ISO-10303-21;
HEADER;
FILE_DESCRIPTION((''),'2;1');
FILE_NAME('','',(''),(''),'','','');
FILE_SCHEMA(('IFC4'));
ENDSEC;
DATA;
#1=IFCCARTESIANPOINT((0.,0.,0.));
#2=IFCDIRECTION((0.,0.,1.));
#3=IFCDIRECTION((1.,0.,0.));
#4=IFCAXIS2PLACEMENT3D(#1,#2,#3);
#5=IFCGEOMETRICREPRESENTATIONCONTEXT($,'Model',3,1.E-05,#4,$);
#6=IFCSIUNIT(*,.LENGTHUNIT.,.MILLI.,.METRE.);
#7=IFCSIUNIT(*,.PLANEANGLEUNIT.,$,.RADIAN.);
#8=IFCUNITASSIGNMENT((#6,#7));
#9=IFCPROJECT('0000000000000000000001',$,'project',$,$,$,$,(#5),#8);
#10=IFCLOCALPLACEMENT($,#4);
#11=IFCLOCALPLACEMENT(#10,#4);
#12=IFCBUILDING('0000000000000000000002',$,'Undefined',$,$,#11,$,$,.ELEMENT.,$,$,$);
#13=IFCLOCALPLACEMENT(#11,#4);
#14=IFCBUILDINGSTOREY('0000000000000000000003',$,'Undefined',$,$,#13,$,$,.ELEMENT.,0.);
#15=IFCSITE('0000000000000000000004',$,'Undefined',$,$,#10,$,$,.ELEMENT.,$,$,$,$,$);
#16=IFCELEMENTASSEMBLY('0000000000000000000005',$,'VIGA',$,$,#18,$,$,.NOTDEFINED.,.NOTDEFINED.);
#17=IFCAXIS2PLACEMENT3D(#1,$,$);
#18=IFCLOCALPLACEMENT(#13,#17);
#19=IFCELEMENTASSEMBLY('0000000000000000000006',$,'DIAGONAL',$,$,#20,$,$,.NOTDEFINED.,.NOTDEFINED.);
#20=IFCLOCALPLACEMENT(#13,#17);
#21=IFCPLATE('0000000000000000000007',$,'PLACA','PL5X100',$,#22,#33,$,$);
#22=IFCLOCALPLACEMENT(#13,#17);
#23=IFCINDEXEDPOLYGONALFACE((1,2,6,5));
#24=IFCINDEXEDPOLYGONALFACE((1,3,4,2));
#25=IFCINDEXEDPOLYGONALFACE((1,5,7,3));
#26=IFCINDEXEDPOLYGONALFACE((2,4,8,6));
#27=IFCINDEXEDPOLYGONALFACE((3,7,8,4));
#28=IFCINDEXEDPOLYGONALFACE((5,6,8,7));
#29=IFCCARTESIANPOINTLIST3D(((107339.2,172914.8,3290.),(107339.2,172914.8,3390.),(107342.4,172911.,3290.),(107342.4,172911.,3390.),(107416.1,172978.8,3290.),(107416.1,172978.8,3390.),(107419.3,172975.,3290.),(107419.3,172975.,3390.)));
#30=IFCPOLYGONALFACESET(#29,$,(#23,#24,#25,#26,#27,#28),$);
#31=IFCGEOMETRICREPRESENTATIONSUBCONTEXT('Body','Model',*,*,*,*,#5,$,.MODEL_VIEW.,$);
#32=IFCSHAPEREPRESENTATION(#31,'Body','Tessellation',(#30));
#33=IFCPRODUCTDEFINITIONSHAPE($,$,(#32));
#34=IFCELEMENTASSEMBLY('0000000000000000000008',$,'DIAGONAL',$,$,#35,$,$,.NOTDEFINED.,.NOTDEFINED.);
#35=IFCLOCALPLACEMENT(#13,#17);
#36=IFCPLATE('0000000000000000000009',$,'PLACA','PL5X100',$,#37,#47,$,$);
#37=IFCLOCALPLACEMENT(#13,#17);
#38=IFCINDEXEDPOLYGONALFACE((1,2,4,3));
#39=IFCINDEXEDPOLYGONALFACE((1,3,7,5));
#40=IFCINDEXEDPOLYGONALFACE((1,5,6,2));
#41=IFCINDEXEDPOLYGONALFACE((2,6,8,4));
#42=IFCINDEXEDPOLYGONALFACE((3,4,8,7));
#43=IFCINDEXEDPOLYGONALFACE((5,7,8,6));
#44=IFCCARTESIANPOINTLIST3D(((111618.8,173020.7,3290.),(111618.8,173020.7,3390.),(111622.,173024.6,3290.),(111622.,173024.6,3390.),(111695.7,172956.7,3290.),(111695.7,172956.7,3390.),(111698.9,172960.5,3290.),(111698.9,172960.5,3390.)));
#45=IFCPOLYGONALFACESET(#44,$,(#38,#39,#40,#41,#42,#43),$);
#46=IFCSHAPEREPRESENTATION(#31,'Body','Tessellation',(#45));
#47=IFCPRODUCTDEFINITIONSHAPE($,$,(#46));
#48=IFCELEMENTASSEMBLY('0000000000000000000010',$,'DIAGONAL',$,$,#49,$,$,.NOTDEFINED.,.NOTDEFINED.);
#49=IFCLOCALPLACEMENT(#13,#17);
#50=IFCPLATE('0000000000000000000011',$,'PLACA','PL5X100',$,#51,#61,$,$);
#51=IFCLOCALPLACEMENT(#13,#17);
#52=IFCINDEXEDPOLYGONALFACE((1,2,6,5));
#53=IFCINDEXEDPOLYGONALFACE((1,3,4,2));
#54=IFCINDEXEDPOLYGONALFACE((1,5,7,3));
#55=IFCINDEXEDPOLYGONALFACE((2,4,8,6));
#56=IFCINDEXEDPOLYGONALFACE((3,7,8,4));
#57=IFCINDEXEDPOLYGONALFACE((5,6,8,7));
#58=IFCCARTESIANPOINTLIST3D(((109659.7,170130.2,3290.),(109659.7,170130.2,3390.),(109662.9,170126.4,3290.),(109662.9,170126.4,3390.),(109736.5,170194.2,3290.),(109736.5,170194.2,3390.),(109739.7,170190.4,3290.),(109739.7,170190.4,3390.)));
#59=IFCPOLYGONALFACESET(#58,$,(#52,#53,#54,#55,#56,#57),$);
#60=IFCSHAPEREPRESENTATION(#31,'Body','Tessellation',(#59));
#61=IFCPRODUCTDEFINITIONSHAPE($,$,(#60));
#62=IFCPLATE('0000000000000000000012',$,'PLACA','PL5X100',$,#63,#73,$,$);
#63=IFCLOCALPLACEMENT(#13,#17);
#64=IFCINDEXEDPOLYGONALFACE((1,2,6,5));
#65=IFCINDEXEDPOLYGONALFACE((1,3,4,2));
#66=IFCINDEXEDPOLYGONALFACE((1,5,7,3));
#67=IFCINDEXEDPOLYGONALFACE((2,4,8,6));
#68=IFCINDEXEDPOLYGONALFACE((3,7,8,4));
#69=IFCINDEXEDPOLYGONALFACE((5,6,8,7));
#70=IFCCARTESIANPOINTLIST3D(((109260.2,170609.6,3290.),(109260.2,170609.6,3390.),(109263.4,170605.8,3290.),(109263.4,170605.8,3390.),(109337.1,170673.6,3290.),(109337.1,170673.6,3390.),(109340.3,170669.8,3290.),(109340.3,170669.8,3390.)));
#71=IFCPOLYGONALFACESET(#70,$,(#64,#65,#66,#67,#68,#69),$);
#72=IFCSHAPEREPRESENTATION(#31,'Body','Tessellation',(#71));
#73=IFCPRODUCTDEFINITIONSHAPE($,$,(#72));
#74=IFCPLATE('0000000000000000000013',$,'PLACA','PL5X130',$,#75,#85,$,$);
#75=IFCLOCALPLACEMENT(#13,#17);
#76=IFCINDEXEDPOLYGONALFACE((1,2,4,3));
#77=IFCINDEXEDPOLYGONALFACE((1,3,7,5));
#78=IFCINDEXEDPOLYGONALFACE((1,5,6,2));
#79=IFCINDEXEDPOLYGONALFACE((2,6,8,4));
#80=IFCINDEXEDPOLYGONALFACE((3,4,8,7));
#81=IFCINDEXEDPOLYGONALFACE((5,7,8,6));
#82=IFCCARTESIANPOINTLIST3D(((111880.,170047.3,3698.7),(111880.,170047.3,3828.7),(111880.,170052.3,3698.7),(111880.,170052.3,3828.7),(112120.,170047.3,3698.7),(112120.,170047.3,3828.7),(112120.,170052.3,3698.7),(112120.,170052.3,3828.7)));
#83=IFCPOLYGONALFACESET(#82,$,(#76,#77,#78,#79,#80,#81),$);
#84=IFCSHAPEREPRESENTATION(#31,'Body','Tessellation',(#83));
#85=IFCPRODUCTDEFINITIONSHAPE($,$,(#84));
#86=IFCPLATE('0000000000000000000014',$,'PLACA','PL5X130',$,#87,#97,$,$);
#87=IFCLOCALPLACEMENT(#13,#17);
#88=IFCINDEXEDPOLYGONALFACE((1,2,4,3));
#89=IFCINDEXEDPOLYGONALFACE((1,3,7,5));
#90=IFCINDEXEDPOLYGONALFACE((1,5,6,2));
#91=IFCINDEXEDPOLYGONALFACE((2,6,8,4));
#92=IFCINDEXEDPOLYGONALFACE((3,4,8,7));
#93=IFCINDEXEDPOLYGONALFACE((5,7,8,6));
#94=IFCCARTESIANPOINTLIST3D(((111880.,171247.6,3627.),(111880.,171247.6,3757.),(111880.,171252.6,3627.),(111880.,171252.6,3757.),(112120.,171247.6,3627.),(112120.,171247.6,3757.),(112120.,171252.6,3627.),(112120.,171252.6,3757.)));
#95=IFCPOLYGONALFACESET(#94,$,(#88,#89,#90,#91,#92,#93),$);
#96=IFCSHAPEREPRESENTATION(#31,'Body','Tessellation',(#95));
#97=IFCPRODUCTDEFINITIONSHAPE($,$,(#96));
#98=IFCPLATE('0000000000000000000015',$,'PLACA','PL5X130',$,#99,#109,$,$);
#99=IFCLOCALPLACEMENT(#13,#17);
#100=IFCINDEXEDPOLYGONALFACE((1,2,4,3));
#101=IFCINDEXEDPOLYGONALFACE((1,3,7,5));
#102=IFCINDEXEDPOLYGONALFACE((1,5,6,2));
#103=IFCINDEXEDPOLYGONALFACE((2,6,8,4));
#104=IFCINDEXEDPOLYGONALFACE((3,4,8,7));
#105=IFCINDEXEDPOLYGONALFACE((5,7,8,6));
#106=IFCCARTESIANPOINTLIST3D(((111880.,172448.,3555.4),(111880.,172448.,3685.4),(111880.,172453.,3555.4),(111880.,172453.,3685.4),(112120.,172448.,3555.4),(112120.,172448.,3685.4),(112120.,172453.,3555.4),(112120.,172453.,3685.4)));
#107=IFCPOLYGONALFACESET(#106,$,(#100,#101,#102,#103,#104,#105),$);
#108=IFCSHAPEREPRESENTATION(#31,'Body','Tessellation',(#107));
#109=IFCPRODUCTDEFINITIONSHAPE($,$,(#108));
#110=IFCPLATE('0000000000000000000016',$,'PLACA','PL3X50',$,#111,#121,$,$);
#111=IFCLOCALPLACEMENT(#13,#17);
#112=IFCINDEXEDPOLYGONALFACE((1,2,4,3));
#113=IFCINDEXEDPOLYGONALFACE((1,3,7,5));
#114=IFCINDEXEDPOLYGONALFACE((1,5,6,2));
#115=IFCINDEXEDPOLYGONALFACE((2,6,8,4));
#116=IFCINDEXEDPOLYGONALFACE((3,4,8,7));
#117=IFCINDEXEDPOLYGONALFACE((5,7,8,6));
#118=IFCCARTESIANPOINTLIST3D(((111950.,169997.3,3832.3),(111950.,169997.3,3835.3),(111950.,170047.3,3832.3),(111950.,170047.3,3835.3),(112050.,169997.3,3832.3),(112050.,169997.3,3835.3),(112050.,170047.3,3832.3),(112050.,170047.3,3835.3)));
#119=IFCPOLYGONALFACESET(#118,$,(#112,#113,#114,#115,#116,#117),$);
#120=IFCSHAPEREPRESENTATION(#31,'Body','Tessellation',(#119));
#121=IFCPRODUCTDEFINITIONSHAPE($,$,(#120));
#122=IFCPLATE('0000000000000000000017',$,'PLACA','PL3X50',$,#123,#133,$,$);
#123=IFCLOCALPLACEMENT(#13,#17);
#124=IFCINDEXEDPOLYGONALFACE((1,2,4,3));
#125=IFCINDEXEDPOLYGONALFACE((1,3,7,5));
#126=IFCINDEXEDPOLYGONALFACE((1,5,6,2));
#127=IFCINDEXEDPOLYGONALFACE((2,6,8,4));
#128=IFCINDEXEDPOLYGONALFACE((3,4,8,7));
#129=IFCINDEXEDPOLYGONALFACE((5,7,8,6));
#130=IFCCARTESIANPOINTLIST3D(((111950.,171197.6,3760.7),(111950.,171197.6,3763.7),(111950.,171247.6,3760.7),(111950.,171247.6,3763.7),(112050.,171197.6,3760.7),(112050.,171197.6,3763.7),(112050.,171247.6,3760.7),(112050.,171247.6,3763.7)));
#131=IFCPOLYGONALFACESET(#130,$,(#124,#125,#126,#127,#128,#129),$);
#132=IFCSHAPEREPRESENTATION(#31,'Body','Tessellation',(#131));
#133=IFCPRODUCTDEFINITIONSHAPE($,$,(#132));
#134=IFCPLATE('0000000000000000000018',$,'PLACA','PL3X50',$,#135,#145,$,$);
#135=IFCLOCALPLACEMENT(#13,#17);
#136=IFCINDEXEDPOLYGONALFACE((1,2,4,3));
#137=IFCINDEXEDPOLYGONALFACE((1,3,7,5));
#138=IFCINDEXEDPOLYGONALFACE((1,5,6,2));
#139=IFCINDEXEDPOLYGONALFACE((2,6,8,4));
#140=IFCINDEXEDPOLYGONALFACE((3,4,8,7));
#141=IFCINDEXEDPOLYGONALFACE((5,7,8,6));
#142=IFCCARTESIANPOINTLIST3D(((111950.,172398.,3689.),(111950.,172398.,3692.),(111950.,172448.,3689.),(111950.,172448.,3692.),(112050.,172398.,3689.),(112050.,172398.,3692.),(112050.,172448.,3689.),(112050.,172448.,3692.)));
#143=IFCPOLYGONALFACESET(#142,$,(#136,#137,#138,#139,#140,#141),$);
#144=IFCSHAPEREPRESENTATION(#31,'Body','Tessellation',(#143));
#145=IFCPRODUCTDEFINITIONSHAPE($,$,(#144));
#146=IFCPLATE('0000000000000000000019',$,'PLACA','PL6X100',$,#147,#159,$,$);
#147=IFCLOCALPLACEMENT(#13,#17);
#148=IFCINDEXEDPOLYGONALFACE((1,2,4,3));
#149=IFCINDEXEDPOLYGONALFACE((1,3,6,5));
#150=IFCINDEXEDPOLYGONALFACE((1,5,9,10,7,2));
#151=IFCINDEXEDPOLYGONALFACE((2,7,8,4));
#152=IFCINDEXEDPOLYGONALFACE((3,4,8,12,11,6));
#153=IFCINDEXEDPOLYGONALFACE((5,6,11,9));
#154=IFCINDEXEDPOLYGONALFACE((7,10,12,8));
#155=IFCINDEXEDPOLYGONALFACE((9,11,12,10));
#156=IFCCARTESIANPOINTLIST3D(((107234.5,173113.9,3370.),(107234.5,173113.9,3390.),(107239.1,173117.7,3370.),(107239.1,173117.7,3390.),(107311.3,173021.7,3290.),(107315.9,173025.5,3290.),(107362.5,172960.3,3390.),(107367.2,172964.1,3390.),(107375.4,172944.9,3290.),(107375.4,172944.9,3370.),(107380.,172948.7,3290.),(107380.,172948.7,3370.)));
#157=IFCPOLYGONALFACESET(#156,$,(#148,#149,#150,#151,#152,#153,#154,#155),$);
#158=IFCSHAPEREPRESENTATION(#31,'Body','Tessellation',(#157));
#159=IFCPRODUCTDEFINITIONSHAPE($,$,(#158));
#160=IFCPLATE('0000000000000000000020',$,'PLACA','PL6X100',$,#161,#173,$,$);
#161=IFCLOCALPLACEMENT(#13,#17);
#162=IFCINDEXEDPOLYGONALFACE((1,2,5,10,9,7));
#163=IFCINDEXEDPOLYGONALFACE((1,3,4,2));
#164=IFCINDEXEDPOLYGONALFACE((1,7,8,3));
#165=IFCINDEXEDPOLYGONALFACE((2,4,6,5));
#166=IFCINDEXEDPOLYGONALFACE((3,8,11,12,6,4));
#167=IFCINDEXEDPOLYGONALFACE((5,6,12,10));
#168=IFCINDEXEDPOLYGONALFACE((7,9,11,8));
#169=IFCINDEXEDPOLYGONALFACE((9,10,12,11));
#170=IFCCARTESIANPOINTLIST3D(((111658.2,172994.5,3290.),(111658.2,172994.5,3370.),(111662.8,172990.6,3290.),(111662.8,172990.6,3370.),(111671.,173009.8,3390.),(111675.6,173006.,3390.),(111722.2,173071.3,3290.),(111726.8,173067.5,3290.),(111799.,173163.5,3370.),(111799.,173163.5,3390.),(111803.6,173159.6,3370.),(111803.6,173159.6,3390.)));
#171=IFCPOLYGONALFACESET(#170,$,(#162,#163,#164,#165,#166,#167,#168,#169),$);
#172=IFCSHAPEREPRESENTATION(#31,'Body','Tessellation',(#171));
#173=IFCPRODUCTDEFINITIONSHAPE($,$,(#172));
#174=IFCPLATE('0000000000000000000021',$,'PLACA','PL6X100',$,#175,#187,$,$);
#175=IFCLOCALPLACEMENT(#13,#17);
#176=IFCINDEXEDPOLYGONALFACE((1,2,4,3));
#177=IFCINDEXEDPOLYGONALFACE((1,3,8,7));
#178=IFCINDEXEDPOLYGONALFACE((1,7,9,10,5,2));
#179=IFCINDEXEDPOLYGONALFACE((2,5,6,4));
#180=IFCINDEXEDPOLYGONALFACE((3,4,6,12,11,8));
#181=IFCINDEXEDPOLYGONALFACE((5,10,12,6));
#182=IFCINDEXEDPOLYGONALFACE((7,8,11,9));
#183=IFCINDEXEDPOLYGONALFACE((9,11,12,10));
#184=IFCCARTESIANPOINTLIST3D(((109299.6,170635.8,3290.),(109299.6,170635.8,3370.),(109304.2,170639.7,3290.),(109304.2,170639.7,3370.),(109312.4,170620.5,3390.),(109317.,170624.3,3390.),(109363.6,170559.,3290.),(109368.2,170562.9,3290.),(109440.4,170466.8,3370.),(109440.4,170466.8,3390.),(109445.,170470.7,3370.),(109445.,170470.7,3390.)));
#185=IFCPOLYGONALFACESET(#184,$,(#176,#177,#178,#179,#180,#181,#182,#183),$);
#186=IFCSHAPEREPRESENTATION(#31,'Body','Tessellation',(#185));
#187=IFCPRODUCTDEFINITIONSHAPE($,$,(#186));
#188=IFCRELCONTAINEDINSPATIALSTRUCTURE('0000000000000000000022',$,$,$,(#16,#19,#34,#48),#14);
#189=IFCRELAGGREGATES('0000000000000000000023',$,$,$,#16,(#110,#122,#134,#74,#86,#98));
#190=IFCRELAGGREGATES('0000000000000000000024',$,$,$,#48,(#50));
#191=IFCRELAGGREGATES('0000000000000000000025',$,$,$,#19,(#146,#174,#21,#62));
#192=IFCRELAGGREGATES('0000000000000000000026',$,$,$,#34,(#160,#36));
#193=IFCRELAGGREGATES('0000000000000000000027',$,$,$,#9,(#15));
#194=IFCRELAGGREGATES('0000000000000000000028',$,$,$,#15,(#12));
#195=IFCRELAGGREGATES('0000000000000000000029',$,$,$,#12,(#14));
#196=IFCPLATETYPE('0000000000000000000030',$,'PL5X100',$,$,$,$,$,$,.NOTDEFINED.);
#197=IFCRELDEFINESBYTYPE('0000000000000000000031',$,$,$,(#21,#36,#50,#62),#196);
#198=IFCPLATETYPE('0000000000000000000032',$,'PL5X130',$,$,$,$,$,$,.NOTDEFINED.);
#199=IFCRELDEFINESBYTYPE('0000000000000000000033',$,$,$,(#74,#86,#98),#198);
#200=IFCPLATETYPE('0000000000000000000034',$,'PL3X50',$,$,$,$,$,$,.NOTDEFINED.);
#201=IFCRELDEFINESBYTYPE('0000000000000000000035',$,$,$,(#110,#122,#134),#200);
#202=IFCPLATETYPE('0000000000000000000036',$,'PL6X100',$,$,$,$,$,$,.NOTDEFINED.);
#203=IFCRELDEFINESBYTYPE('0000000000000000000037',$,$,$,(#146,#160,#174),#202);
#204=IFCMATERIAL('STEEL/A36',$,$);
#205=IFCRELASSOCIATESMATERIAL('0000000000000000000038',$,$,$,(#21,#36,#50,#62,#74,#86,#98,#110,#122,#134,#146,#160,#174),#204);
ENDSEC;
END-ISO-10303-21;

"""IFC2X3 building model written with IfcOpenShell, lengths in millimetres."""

from ifc_helpers import new_model, si_unit, frame, origin_with_axes, place, context, subcontext, project, spatial, polyline, outline, extrude, material, type_object, element, aggregate, save


model = new_model("IFC2X3")

# Units and contexts
model_context = context("Model", 3, precision=1e-05, world=origin_with_axes())
body_context = subcontext(model_context, "Body", "Model", "MODEL_VIEW")
ifc_project = project(units=[si_unit("LENGTHUNIT", "METRE", prefix="MILLI"), si_unit("PLANEANGLEUNIT", "RADIAN")], contexts=[model_context])

# Site, building, storey
site_placement = place(None, origin_with_axes())
site = spatial("IfcSite", under=ifc_project, at=site_placement, Name="Undefined", CompositionType="ELEMENT")
building_placement = place(site_placement, origin_with_axes())
building = spatial("IfcBuilding", under=site, at=building_placement, Name="Undefined", CompositionType="ELEMENT")
storey_placement = place(building_placement, origin_with_axes())
storey = spatial("IfcBuildingStorey", under=building, at=storey_placement, Name="Undefined", CompositionType="ELEMENT", Elevation=0.0)

# Element assembly
assembly_1_placement = place(storey_placement, origin_with_axes())
assembly_1 = element("IfcElementAssembly", 1, at=assembly_1_placement, inside=storey, Name="VIGA", AssemblyPlace="NOTDEFINED", PredefinedType="NOTDEFINED")
ifc_material_1 = material(Name="STEEL/A36")

# Element assembly, plate
assembly_2_placement = place(storey_placement, origin_with_axes())
assembly_2 = element("IfcElementAssembly", 2, at=assembly_2_placement, inside=storey, Name="DIAGONAL", AssemblyPlace="NOTDEFINED", PredefinedType="NOTDEFINED")
plate_type_1 = type_object("IfcPlateType", Name="PL5X100", PredefinedType="NOTDEFINED")
plate_1_placement = place(assembly_2_placement, frame((107379.3, 172944.9, 3390.0), z_axis=(0.640185, -0.768221, 0.0), x_axis=(0.0, 0.0, -1.0)))
plate_1 = element("IfcPlate", 3, at=plate_1_placement, type_object=plate_type_1, material=ifc_material_1, Name="PLACA", Description="PL5X100", context=body_context, shape_type="SweptSolid", body=[
    extrude(outline(polyline([(0.0, -50.0), (0.0, 50.0), (100.0, 50.0), (100.0, -50.0), (0.0, -50.0)])), frame((0.0, 0.0, -2.5), z_axis=(0.0, 0.0, 1.0), x_axis=(1.0, 0.0, 0.0)), (0.0, 0.0, 1.0), 5.0),
])

# Element assemblies, plates
assembly_3_placement = place(storey_placement, origin_with_axes())
assembly_3 = element("IfcElementAssembly", 4, at=assembly_3_placement, inside=storey, Name="DIAGONAL", AssemblyPlace="NOTDEFINED", PredefinedType="NOTDEFINED")
plate_2_placement = place(assembly_3_placement, frame((111620.4, 173022.6, 3390.0), z_axis=(-0.640185, -0.768221, 0.0), x_axis=(0.0, 0.0, -1.0)))
plate_2 = element("IfcPlate", 5, at=plate_2_placement, type_object=plate_type_1, material=ifc_material_1, Name="PLACA", Description="PL5X100", context=body_context, shape_type="SweptSolid", body=[
    extrude(outline(polyline([(0.0, 0.0), (100.0, 0.0), (100.0, 100.0), (0.0, 100.0), (0.0, 0.0)])), frame((0.0, 0.0, -2.5), z_axis=(0.0, 0.0, 1.0), x_axis=(1.0, 0.0, 0.0)), (0.0, 0.0, 1.0), 5.0),
])
assembly_4_placement = place(storey_placement, origin_with_axes())
assembly_4 = element("IfcElementAssembly", 6, at=assembly_4_placement, inside=storey, Name="DIAGONAL", AssemblyPlace="NOTDEFINED", PredefinedType="NOTDEFINED")
plate_3_placement = place(assembly_4_placement, frame((109699.7, 170160.3, 3390.0), z_axis=(0.640185, -0.768221, 0.0), x_axis=(0.0, 0.0, -1.0)))
plate_3 = element("IfcPlate", 7, at=plate_3_placement, type_object=plate_type_1, material=ifc_material_1, Name="PLACA", Description="PL5X100", context=body_context, shape_type="SweptSolid", body=[
    extrude(outline(polyline([(0.0, -50.0), (0.0, 50.0), (100.0, 50.0), (100.0, -50.0), (0.0, -50.0)])), frame((0.0, 0.0, -2.5), z_axis=(0.0, 0.0, 1.0), x_axis=(1.0, 0.0, 0.0)), (0.0, 0.0, 1.0), 5.0),
])

# Plates
plate_4_placement = place(assembly_2_placement, frame((109300.3, 170639.7, 3390.0), z_axis=(-0.640185, 0.768221, 0.0), x_axis=(0.0, 0.0, -1.0)))
plate_4 = element("IfcPlate", 8, at=plate_4_placement, type_object=plate_type_1, material=ifc_material_1, Name="PLACA", Description="PL5X100", context=body_context, shape_type="SweptSolid", body=[
    extrude(outline(polyline([(0.0, -50.0), (0.0, 50.0), (100.0, 50.0), (100.0, -50.0), (0.0, -50.0)])), frame((0.0, 0.0, -2.5), z_axis=(0.0, 0.0, 1.0), x_axis=(1.0, 0.0, 0.0)), (0.0, 0.0, 1.0), 5.0),
])
plate_type_2 = type_object("IfcPlateType", Name="PL5X130", PredefinedType="NOTDEFINED")
plate_5_placement = place(assembly_1_placement, frame((111880.0, 170049.8, 3828.7), z_axis=(0.0, 1.0, 0.0), x_axis=(1.0, 0.0, 0.000002)))
plate_5 = element("IfcPlate", 9, at=plate_5_placement, type_object=plate_type_2, material=ifc_material_1, Name="PLACA", Description="PL5X130", context=body_context, shape_type="SweptSolid", body=[
    extrude(outline(polyline([(0.0, 0.0), (240.0, 0.0), (240.0, 130.0), (0.0, 130.0), (0.0, 0.0)])), frame((0.0, 0.0, -2.5), z_axis=(0.0, 0.0, 1.0), x_axis=(1.0, 0.0, 0.0)), (0.0, 0.0, 1.0), 5.0),
])
plate_6_placement = place(assembly_1_placement, frame((111880.0, 171250.1, 3757.0), z_axis=(0.0, 1.0, 0.0), x_axis=(1.0, 0.0, 0.000002)))
plate_6 = element("IfcPlate", 10, at=plate_6_placement, type_object=plate_type_2, material=ifc_material_1, Name="PLACA", Description="PL5X130", context=body_context, shape_type="SweptSolid", body=[
    extrude(outline(polyline([(0.0, 0.0), (240.0, 0.0), (240.0, 130.0), (0.0, 130.0), (0.0, 0.0)])), frame((0.0, 0.0, -2.5), z_axis=(0.0, 0.0, 1.0), x_axis=(1.0, 0.0, 0.0)), (0.0, 0.0, 1.0), 5.0),
])
plate_7_placement = place(assembly_1_placement, frame((111880.0, 172450.5, 3685.4), z_axis=(0.0, 1.0, 0.0), x_axis=(1.0, 0.0, 0.000002)))
plate_7 = element("IfcPlate", 11, at=plate_7_placement, type_object=plate_type_2, material=ifc_material_1, Name="PLACA", Description="PL5X130", context=body_context, shape_type="SweptSolid", body=[
    extrude(outline(polyline([(0.0, 0.0), (240.0, 0.0), (240.0, 130.0), (0.0, 130.0), (0.0, 0.0)])), frame((0.0, 0.0, -2.5), z_axis=(0.0, 0.0, 1.0), x_axis=(1.0, 0.0, 0.0)), (0.0, 0.0, 1.0), 5.0),
])
plate_type_3 = type_object("IfcPlateType", Name="PL3X50", PredefinedType="NOTDEFINED")
plate_8_placement = place(assembly_1_placement, frame((112050.0, 170047.3, 3833.8), z_axis=(-0.000002, 0.0, 1.0), x_axis=(-1.0, 0.0, -0.000002)))
plate_8 = element("IfcPlate", 12, at=plate_8_placement, type_object=plate_type_3, material=ifc_material_1, Name="PLACA", Description="PL3X50", context=body_context, shape_type="SweptSolid", body=[
    extrude(outline(polyline([(0.0, 0.0), (100.0, 0.0), (100.0, 50.0), (0.0, 50.0), (0.0, 0.0)])), frame((0.0, 0.0, -1.5), z_axis=(0.0, 0.0, 1.0), x_axis=(1.0, 0.0, 0.0)), (0.0, 0.0, 1.0), 3.0),
])
plate_9_placement = place(assembly_1_placement, frame((112050.0, 171247.6, 3762.2), z_axis=(-0.000002, 0.0, 1.0), x_axis=(-1.0, 0.0, -0.000002)))
plate_9 = element("IfcPlate", 13, at=plate_9_placement, type_object=plate_type_3, material=ifc_material_1, Name="PLACA", Description="PL3X50", context=body_context, shape_type="SweptSolid", body=[
    extrude(outline(polyline([(0.0, 0.0), (100.0, 0.0), (100.0, 50.0), (0.0, 50.0), (0.0, 0.0)])), frame((0.0, 0.0, -1.5), z_axis=(0.0, 0.0, 1.0), x_axis=(1.0, 0.0, 0.0)), (0.0, 0.0, 1.0), 3.0),
])
plate_10_placement = place(assembly_1_placement, frame((112050.0, 172448.0, 3690.5), z_axis=(-0.000002, 0.0, 1.0), x_axis=(-1.0, 0.0, -0.000002)))
plate_10 = element("IfcPlate", 14, at=plate_10_placement, type_object=plate_type_3, material=ifc_material_1, Name="PLACA", Description="PL3X50", context=body_context, shape_type="SweptSolid", body=[
    extrude(outline(polyline([(0.0, 0.0), (100.0, 0.0), (100.0, 50.0), (0.0, 50.0), (0.0, 0.0)])), frame((0.0, 0.0, -1.5), z_axis=(0.0, 0.0, 1.0), x_axis=(1.0, 0.0, 0.0)), (0.0, 0.0, 1.0), 3.0),
])
aggregate(assembly_1, [plate_8, plate_9, plate_10, plate_5, plate_6, plate_7])
plate_type_4 = type_object("IfcPlateType", Name="PL6X100", PredefinedType="NOTDEFINED")
plate_11_placement = place(assembly_2_placement, frame((107236.8, 173115.8, 3290.0), z_axis=(-0.768221, -0.640185, 0.0), x_axis=(0.640185, -0.768221, 0.0)))
plate_11 = element("IfcPlate", 15, at=plate_11_placement, type_object=plate_type_4, material=ifc_material_1, Name="PLACA", Description="PL6X100", context=body_context, shape_type="SweptSolid", body=[
    extrude(outline(polyline([(0.0, 80.0), (120.0, 0.0), (220.0, 0.0), (220.0, 80.0), (200.0, 100.0), (0.0, 100.0), (0.0, 80.0)])), frame((0.0, 0.0, -3.0), z_axis=(0.0, 0.0, 1.0), x_axis=(1.0, 0.0, 0.0)), (0.0, 0.0, 1.0), 6.0),
])
plate_12_placement = place(assembly_3_placement, frame((111801.3, 173161.6, 3290.0), z_axis=(-0.768221, 0.640185, 0.0), x_axis=(-0.640185, -0.768221, 0.0)))
plate_12 = element("IfcPlate", 16, at=plate_12_placement, type_object=plate_type_4, material=ifc_material_1, Name="PLACA", Description="PL6X100", context=body_context, shape_type="SweptSolid", body=[
    extrude(outline(polyline([(0.0, 80.0), (120.0, 0.0), (220.0, 0.0), (220.0, 80.0), (200.0, 100.0), (0.0, 100.0), (0.0, 80.0)])), frame((0.0, 0.0, -3.0), z_axis=(0.0, 0.0, 1.0), x_axis=(1.0, 0.0, 0.0)), (0.0, 0.0, 1.0), 6.0),
])
plate_13_placement = place(assembly_2_placement, frame((109442.7, 170468.8, 3290.0), z_axis=(0.768221, 0.640185, 0.0), x_axis=(-0.640185, 0.768221, 0.0)))
plate_13 = element("IfcPlate", 17, at=plate_13_placement, type_object=plate_type_4, material=ifc_material_1, Name="PLACA", Description="PL6X100", context=body_context, shape_type="SweptSolid", body=[
    extrude(outline(polyline([(0.0, 80.0), (120.0, 0.0), (220.0, 0.0), (220.0, 80.0), (200.0, 100.0), (0.0, 100.0), (0.0, 80.0)])), frame((0.0, 0.0, -3.0), z_axis=(0.0, 0.0, 1.0), x_axis=(1.0, 0.0, 0.0)), (0.0, 0.0, 1.0), 6.0),
])

aggregate(assembly_4, [plate_3])
aggregate(assembly_2, [plate_11, plate_13, plate_1, plate_4])

aggregate(assembly_3, [plate_12, plate_2])

save(model, "model.ifc")
